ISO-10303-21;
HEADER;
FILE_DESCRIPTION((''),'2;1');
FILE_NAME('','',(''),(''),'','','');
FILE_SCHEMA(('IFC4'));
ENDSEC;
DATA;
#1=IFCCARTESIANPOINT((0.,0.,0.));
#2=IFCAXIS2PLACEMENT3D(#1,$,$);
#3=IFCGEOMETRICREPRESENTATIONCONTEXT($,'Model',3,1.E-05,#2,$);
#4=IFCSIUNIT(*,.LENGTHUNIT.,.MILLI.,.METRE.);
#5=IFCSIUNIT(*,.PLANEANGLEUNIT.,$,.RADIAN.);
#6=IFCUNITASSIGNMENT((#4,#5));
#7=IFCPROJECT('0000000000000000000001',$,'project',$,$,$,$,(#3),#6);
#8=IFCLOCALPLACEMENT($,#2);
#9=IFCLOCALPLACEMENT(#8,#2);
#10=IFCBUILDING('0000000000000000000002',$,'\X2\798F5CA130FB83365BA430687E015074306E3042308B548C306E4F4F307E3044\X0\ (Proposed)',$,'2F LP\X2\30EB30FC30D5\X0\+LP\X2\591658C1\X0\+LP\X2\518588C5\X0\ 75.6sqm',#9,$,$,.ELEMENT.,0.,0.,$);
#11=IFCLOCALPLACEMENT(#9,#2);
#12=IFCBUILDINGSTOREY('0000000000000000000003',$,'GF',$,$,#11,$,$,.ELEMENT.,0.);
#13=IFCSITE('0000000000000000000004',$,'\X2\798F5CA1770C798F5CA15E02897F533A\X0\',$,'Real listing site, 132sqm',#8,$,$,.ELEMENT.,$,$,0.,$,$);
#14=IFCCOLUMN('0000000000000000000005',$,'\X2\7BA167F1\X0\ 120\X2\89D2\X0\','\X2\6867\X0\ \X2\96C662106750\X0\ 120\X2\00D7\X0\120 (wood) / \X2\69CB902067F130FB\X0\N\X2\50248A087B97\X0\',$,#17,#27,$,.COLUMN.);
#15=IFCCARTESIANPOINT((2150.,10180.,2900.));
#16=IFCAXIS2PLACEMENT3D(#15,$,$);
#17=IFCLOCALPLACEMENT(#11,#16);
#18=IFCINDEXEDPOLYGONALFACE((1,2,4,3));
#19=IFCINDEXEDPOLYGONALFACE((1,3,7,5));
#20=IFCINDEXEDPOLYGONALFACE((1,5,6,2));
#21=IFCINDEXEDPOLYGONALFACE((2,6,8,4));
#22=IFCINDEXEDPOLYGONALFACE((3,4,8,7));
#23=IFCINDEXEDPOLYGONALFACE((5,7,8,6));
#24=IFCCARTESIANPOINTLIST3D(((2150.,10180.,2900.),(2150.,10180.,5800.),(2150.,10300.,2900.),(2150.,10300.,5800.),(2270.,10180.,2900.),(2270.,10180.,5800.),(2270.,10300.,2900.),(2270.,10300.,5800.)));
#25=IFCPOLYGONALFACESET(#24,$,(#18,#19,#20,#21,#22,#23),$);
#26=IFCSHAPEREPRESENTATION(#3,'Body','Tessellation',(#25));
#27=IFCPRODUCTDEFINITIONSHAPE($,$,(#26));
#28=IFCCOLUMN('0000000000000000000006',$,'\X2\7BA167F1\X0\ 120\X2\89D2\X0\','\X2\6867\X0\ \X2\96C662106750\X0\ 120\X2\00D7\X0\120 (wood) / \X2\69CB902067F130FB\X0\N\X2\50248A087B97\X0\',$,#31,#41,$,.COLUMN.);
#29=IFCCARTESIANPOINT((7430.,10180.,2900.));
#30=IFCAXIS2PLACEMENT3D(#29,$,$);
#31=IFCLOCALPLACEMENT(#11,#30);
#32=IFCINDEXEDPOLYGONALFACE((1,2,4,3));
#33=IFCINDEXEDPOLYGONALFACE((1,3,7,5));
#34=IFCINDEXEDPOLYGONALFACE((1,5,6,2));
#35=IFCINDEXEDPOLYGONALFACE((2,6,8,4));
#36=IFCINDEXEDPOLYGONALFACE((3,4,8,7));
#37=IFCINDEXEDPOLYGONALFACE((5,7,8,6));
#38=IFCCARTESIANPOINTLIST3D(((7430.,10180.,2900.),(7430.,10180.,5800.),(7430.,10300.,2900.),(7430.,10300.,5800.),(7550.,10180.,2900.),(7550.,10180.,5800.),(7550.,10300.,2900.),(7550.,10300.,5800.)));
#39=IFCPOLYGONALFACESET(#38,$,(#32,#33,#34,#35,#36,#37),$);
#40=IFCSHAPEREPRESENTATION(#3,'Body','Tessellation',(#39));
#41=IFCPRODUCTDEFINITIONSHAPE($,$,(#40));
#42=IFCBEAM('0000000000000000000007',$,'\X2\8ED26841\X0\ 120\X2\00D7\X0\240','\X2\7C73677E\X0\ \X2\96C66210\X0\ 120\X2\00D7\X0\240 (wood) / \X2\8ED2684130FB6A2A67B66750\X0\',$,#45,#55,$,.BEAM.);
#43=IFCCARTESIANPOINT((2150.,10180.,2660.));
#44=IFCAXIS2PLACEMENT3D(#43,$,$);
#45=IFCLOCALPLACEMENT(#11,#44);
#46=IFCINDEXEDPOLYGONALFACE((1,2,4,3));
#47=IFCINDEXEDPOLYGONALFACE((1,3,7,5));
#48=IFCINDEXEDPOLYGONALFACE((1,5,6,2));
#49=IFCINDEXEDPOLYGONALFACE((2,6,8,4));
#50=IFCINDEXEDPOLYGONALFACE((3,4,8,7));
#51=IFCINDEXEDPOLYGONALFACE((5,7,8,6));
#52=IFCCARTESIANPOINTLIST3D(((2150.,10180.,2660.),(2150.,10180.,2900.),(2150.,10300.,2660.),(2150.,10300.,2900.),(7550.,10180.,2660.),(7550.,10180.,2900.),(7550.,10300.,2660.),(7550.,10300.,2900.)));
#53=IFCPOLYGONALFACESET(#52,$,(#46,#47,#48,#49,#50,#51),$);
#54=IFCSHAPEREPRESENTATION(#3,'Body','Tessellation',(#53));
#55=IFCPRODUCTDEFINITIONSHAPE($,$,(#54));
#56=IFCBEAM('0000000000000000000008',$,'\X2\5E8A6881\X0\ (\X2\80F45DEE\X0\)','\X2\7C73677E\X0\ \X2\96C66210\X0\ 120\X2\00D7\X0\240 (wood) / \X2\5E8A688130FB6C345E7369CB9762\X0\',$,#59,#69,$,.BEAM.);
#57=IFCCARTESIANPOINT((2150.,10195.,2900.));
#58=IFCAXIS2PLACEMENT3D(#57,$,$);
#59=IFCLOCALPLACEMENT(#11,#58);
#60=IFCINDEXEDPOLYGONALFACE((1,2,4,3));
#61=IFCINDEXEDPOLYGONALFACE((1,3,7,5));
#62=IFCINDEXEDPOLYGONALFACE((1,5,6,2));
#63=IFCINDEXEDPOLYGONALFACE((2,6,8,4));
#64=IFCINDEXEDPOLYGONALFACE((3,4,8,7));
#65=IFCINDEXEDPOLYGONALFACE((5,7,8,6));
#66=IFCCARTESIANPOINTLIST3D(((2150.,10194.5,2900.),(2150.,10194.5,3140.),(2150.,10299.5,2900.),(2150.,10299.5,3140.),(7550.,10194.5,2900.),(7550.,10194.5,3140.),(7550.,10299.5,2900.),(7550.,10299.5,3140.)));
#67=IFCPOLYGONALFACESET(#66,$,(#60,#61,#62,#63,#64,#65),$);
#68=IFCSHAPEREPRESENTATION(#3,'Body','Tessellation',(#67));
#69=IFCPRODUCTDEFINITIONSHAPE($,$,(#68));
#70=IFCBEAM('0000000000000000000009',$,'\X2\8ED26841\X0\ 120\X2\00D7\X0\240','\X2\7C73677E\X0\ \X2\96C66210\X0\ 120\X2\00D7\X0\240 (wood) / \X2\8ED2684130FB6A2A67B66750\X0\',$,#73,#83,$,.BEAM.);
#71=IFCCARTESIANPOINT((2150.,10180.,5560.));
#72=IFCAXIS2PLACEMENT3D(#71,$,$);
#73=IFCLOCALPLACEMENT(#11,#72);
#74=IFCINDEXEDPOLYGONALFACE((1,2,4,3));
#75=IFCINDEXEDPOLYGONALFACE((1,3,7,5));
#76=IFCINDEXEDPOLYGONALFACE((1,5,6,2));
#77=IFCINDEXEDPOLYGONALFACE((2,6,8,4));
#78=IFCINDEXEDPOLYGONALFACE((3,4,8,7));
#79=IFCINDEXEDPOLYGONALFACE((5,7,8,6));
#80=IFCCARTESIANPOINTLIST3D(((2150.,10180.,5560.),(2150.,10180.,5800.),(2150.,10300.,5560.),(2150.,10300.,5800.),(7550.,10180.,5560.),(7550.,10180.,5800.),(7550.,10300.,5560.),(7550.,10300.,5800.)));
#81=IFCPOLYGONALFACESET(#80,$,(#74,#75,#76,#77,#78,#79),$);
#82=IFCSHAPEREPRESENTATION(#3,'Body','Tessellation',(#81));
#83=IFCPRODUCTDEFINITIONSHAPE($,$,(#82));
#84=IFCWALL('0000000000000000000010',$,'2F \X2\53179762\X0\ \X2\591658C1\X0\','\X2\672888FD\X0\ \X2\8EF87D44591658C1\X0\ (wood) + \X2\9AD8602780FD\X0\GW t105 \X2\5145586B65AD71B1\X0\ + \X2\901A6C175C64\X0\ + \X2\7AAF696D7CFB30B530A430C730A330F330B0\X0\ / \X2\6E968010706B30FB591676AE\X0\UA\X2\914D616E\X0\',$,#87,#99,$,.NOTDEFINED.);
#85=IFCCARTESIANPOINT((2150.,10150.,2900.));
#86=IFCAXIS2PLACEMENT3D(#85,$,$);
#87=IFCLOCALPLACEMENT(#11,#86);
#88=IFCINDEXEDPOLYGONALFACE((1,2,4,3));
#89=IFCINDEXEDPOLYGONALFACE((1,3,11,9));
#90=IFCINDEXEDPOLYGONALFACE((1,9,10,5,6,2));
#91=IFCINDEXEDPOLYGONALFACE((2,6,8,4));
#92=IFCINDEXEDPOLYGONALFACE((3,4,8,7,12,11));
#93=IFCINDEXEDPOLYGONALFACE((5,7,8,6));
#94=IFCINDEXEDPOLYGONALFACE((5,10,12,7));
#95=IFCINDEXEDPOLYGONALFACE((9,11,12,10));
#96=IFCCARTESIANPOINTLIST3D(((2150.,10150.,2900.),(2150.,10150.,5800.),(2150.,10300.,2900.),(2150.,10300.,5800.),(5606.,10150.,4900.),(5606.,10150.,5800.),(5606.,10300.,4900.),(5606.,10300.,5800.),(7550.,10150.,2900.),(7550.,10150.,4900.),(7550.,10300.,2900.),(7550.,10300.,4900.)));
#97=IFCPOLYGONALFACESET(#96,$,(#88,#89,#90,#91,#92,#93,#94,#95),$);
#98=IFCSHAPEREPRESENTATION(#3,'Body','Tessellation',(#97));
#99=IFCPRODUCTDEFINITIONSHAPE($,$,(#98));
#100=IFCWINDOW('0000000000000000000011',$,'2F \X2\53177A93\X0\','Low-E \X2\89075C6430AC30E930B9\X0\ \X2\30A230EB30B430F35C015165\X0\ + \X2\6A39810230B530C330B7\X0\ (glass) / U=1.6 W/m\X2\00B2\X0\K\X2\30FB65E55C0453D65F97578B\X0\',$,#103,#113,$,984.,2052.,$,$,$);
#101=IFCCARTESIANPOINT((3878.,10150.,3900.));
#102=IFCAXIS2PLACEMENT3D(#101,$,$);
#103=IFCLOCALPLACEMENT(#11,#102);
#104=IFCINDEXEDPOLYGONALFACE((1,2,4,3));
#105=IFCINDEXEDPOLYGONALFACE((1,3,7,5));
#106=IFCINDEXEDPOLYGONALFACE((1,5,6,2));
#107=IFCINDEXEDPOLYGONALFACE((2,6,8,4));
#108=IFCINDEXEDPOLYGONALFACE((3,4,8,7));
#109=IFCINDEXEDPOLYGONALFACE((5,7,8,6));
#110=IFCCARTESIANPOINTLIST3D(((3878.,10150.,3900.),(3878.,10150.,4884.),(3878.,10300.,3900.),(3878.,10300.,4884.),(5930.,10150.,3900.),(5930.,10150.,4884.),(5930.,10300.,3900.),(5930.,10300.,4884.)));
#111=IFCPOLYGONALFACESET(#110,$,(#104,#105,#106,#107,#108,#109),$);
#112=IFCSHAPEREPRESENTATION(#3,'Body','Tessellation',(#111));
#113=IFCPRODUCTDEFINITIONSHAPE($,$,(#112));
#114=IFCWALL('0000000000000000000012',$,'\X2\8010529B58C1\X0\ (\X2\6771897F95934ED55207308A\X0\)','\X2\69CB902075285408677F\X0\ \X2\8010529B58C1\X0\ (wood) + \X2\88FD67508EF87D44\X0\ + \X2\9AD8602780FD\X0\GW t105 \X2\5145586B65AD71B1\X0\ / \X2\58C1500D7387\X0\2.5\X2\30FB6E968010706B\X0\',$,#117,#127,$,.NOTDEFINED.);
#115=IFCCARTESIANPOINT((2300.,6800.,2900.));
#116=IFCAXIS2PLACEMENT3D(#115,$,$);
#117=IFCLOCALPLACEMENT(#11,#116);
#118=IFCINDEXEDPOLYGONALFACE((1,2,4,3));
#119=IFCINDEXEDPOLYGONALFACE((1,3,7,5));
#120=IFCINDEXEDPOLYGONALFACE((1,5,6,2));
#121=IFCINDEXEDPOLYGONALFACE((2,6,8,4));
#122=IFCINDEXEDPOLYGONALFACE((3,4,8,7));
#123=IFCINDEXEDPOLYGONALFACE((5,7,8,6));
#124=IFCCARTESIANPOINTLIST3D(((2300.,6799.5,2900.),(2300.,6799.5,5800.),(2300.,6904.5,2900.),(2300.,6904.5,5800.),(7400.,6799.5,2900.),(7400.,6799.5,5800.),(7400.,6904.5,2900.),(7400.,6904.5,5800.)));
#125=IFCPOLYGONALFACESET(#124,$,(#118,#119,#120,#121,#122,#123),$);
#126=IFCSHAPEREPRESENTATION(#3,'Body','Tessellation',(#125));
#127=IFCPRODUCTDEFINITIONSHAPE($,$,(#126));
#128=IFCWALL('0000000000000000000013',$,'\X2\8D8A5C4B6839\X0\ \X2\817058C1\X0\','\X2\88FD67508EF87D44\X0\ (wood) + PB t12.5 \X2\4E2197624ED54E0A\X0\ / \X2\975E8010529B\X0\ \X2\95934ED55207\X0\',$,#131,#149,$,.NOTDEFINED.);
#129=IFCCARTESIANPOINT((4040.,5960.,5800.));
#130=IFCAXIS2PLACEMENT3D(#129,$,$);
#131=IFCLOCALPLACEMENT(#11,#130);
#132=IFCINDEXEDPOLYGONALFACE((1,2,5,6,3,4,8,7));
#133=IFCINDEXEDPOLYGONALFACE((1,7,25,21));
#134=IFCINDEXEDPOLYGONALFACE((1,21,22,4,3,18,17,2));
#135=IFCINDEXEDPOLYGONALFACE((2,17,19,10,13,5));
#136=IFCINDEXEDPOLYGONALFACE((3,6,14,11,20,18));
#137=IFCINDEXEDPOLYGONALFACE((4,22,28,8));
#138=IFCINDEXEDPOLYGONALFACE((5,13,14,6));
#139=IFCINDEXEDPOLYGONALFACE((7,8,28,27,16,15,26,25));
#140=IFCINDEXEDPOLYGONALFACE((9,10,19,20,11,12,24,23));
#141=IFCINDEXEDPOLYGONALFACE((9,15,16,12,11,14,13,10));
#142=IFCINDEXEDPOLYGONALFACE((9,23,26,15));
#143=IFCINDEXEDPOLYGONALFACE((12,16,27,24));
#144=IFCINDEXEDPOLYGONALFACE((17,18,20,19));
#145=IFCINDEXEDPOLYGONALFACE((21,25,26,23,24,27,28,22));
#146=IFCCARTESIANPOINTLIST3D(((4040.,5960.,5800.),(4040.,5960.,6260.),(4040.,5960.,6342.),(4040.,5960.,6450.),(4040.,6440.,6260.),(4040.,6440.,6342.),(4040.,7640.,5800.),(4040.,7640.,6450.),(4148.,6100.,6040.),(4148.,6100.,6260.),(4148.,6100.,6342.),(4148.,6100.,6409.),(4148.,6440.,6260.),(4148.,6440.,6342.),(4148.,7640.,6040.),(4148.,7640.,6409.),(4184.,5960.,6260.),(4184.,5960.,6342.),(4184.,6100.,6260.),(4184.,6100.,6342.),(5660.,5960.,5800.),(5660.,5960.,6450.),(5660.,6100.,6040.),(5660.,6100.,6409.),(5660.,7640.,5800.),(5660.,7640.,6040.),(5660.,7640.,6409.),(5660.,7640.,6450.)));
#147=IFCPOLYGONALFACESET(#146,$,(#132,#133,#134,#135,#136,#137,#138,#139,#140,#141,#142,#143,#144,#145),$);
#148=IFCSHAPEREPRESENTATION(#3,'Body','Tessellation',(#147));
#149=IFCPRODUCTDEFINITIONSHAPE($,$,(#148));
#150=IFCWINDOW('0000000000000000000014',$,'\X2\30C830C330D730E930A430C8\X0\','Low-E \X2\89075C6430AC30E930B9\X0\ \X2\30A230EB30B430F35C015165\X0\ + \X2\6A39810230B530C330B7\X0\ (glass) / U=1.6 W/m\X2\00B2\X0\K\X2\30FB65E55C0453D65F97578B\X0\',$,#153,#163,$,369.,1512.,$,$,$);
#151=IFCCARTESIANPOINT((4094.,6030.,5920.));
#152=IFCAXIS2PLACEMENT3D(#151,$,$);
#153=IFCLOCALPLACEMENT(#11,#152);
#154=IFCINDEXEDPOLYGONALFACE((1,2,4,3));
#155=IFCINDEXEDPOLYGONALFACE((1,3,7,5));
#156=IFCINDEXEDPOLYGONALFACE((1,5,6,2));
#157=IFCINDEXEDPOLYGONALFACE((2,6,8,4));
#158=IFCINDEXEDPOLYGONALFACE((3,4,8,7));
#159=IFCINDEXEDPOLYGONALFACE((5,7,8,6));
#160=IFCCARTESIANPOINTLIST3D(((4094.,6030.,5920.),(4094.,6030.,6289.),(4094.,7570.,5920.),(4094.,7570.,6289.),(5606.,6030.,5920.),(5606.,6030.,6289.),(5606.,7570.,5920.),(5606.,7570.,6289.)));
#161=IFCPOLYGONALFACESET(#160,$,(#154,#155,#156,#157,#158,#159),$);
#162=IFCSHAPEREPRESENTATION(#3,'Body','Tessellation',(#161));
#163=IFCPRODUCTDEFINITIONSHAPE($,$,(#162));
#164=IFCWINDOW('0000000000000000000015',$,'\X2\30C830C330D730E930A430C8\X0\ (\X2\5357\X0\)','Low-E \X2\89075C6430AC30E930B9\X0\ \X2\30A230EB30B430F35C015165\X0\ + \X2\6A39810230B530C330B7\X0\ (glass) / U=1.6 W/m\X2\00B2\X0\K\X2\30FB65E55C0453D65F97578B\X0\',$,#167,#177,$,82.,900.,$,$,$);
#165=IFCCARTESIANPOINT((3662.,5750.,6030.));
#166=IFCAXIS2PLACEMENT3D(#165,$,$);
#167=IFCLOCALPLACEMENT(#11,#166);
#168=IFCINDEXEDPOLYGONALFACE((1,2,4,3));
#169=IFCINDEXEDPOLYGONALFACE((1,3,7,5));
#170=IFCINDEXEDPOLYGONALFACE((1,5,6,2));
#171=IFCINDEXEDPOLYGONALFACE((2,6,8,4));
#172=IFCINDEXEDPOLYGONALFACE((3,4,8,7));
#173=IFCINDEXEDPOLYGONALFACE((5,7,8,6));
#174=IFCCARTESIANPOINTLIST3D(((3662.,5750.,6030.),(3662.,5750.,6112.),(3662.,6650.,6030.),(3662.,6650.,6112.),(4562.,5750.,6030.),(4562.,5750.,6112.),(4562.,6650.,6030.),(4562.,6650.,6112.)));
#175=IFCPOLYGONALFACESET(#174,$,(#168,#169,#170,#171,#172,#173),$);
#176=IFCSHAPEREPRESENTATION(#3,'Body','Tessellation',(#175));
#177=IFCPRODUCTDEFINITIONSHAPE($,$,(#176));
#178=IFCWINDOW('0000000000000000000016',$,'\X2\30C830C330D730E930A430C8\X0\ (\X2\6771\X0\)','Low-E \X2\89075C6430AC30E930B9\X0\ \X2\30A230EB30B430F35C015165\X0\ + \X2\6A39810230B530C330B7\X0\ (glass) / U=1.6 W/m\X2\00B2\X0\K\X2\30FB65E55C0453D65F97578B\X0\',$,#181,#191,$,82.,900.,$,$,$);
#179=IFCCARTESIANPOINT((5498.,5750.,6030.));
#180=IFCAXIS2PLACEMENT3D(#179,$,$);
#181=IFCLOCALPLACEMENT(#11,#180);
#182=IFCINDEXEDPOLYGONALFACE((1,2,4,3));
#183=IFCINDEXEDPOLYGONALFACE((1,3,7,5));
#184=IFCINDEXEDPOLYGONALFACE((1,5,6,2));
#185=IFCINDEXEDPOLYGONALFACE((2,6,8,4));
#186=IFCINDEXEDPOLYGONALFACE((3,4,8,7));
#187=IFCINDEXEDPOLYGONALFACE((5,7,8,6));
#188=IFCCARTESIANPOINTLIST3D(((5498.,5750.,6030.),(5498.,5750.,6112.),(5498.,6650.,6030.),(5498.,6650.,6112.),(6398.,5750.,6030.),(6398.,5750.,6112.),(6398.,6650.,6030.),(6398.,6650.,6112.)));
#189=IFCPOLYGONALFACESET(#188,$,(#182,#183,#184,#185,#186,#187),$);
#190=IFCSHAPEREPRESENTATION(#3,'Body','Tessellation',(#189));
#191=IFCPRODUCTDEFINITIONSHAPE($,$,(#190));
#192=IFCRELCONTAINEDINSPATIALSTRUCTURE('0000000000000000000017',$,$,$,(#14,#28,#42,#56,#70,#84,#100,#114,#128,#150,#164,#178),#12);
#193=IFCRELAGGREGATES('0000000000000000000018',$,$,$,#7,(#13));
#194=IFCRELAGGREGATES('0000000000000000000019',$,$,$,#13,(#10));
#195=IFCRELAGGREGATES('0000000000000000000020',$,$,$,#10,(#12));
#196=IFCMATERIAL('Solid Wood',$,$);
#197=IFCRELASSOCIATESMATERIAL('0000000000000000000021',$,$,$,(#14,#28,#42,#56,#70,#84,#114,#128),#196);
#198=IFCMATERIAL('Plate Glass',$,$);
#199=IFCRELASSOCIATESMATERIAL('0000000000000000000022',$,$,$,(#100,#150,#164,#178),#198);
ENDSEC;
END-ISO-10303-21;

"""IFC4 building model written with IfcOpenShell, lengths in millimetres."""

from ifc_helpers import new_model, si_unit, frame, frame_2d, origin, place, context, project, spatial, rectangle, extrude, material, element, fill, save


model = new_model("IFC4")

# Units and contexts
model_context = context("Model", 3, precision=1e-05, world=origin())
ifc_project = project(units=[si_unit("LENGTHUNIT", "METRE", prefix="MILLI"), si_unit("PLANEANGLEUNIT", "RADIAN")], contexts=[model_context])

# Site, building, storey
site_placement = place(None, origin())
site = spatial("IfcSite", under=ifc_project, at=site_placement, Name="福岡県福岡市西区", ObjectType="Real listing site, 132sqm", CompositionType="ELEMENT", RefElevation=0.0)
building_placement = place(site_placement, origin())
building = spatial("IfcBuilding", under=site, at=building_placement, Name="福岡・茶室と縁側のある和の住まい (Proposed)", ObjectType="2F LPルーフ+LP外壁+LP内装 75.6sqm", CompositionType="ELEMENT", ElevationOfRefHeight=0.0, ElevationOfTerrain=0.0)
storey_placement = place(building_placement, origin())
storey = spatial("IfcBuildingStorey", under=building, at=storey_placement, Name="GF", CompositionType="ELEMENT", Elevation=0.0)

# Columns
ifc_material_1 = material(Name="Solid Wood")
column_1_placement = place(storey_placement, frame((2150.0, 10180.0, 2900.0)))
element("IfcColumn", 1, at=column_1_placement, inside=storey, material=ifc_material_1, Name="管柱 120角", Description="桧 集成材 120×120 (wood) / 構造柱・N値計算", PredefinedType="COLUMN", context=model_context, shape_type="SweptSolid", body=[
    extrude(rectangle(XDim=120.0, YDim=120.0, at=frame_2d((60.0, 60.0))), frame((2150.0, 10180.0, 2900.0)), (0.0, 0.0, 1.0), 2900.0),
])
column_2_placement = place(storey_placement, frame((7430.0, 10180.0, 2900.0)))
element("IfcColumn", 2, at=column_2_placement, inside=storey, material=ifc_material_1, Name="管柱 120角", Description="桧 集成材 120×120 (wood) / 構造柱・N値計算", PredefinedType="COLUMN", context=model_context, shape_type="SweptSolid", body=[
    extrude(rectangle(XDim=120.0, YDim=120.0, at=frame_2d((60.0, 60.0))), frame((7430.0, 10180.0, 2900.0)), (0.0, 0.0, 1.0), 2900.0),
])

# Beams
beam_1_placement = place(storey_placement, frame((2150.0, 10180.0, 2660.0)))
element("IfcBeam", 3, at=beam_1_placement, inside=storey, material=ifc_material_1, Name="軒桁 120×240", Description="米松 集成 120×240 (wood) / 軒桁・横架材", PredefinedType="BEAM", context=model_context, shape_type="SweptSolid", body=[
    extrude(rectangle(XDim=5400.0, YDim=120.0, at=frame_2d((2700.0, 60.0))), frame((2150.0, 10180.0, 2660.0)), (0.0, 0.0, 1.0), 240.0),
])
beam_2_placement = place(storey_placement, frame((2150.0, 10195.0, 2900.0)))
element("IfcBeam", 4, at=beam_2_placement, inside=storey, material=ifc_material_1, Name="床梁 (胴差)", Description="米松 集成 120×240 (wood) / 床梁・水平構面", PredefinedType="BEAM", context=model_context, shape_type="SweptSolid", body=[
    extrude(rectangle(XDim=5400.0, YDim=105.0, at=frame_2d((2700.0, 52.0))), frame((2150.0, 10195.0, 2900.0)), (0.0, 0.0, 1.0), 240.0),
])
beam_3_placement = place(storey_placement, frame((2150.0, 10180.0, 5560.0)))
element("IfcBeam", 5, at=beam_3_placement, inside=storey, material=ifc_material_1, Name="軒桁 120×240", Description="米松 集成 120×240 (wood) / 軒桁・横架材", PredefinedType="BEAM", context=model_context, shape_type="SweptSolid", body=[
    extrude(rectangle(XDim=5400.0, YDim=120.0, at=frame_2d((2700.0, 60.0))), frame((2150.0, 10180.0, 5560.0)), (0.0, 0.0, 1.0), 240.0),
])

# Wall, opening, window
wall_1_placement = place(storey_placement, frame((2150.0, 10150.0, 2900.0)))
wall_1 = element("IfcWall", 6, at=wall_1_placement, inside=storey, material=ifc_material_1, Name="2F 北面 外壁", Description="木製 軸組外壁 (wood) + 高性能GW t105 充填断熱 + 通気層 + 窯業系サイディング / 準耐火・外皮UA配慮", PredefinedType="NOTDEFINED", context=model_context, shape_type="SweptSolid", body=[
    extrude(rectangle(XDim=5400.0, YDim=150.0, at=frame_2d((2700.0, 75.0))), frame((2150.0, 10150.0, 2900.0)), (0.0, 0.0, 1.0), 2900.0),
])
opening_1_placement = place(storey_placement, frame((3878.0, 10150.0, 3900.0)))
opening_1 = element("IfcOpeningElement", 7, at=opening_1_placement, cuts=wall_1, PredefinedType="NOTDEFINED", context=model_context, shape_type="SweptSolid", body=[
    extrude(rectangle(XDim=2052.0, YDim=150.0, at=frame_2d((1026.0, 75.0))), frame((3878.0, 10150.0, 3900.0)), (0.0, 0.0, 1.0), 984.0),
])
ifc_material_2 = material(Name="Plate Glass")
window_1_placement = place(storey_placement, frame((3878.0, 10150.0, 3900.0)))
window_1 = element("IfcWindow", 8, at=window_1_placement, inside=storey, material=ifc_material_2, Name="2F 北窓", Description="Low-E 複層ガラス アルゴン封入 + 樹脂サッシ (glass) / U=1.6 W/m²K・日射取得型", OverallHeight=984.0, OverallWidth=2052.0, context=model_context, shape_type="SweptSolid", body=[
    extrude(rectangle(XDim=2052.0, YDim=150.0, at=frame_2d((1026.0, 75.0))), frame((3878.0, 10150.0, 3900.0)), (0.0, 0.0, 1.0), 984.0),
])
fill(opening_1, window_1)

# Wall
wall_2_placement = place(storey_placement, frame((2300.0, 6800.0, 2900.0)))
element("IfcWall", 9, at=wall_2_placement, inside=storey, material=ifc_material_1, Name="耐力壁 (東西間仕切り)", Description="構造用合板 耐力壁 (wood) + 製材軸組 + 高性能GW t105 充填断熱 / 壁倍率2.5・準耐火", PredefinedType="NOTDEFINED", context=model_context, shape_type="SweptSolid", body=[
    extrude(rectangle(XDim=5100.0, YDim=105.0, at=frame_2d((2550.0, 52.0))), frame((2300.0, 6800.0, 2900.0)), (0.0, 0.0, 1.0), 2900.0),
])

# Wall, openings, windows
wall_3_placement = place(storey_placement, frame((4040.0, 5960.0, 5800.0)))
wall_3 = element("IfcWall", 10, at=wall_3_placement, inside=storey, material=ifc_material_1, Name="越屋根 腰壁", Description="製材軸組 (wood) + PB t12.5 両面仕上 / 非耐力 間仕切", PredefinedType="NOTDEFINED", context=model_context, shape_type="SweptSolid", body=[
    extrude(rectangle(XDim=1620.0, YDim=1680.0, at=frame_2d((810.0, 840.0))), frame((4040.0, 5960.0, 5800.0)), (0.0, 0.0, 1.0), 650.0),
])
opening_2_placement = place(storey_placement, frame((4094.0, 6030.0, 5920.0)))
opening_2 = element("IfcOpeningElement", 11, at=opening_2_placement, cuts=wall_3, PredefinedType="NOTDEFINED", context=model_context, shape_type="SweptSolid", body=[
    extrude(rectangle(XDim=1512.0, YDim=1540.0, at=frame_2d((756.0, 770.0))), frame((4094.0, 6030.0, 5920.0)), (0.0, 0.0, 1.0), 369.0),
])
opening_3_placement = place(storey_placement, frame((3662.0, 5750.0, 6030.0)))
opening_3 = element("IfcOpeningElement", 12, at=opening_3_placement, cuts=wall_3, PredefinedType="NOTDEFINED", context=model_context, shape_type="SweptSolid", body=[
    extrude(rectangle(XDim=900.0, YDim=900.0, at=frame_2d((450.0, 450.0))), frame((3662.0, 5750.0, 6030.0)), (0.0, 0.0, 1.0), 82.0),
])
opening_4_placement = place(storey_placement, frame((5498.0, 5750.0, 6030.0)))
opening_4 = element("IfcOpeningElement", 13, at=opening_4_placement, cuts=wall_3, PredefinedType="NOTDEFINED", context=model_context, shape_type="SweptSolid", body=[
    extrude(rectangle(XDim=900.0, YDim=900.0, at=frame_2d((450.0, 450.0))), frame((5498.0, 5750.0, 6030.0)), (0.0, 0.0, 1.0), 82.0),
])
window_2_placement = place(storey_placement, frame((4094.0, 6030.0, 5920.0)))
window_2 = element("IfcWindow", 14, at=window_2_placement, inside=storey, material=ifc_material_2, Name="トップライト", Description="Low-E 複層ガラス アルゴン封入 + 樹脂サッシ (glass) / U=1.6 W/m²K・日射取得型", OverallHeight=369.0, OverallWidth=1512.0, context=model_context, shape_type="SweptSolid", body=[
    extrude(rectangle(XDim=1512.0, YDim=1540.0, at=frame_2d((756.0, 770.0))), frame((4094.0, 6030.0, 5920.0)), (0.0, 0.0, 1.0), 369.0),
])
fill(opening_2, window_2)
window_3_placement = place(storey_placement, frame((3662.0, 5750.0, 6030.0)))
window_3 = element("IfcWindow", 15, at=window_3_placement, inside=storey, material=ifc_material_2, Name="トップライト (南)", Description="Low-E 複層ガラス アルゴン封入 + 樹脂サッシ (glass) / U=1.6 W/m²K・日射取得型", OverallHeight=82.0, OverallWidth=900.0, context=model_context, shape_type="SweptSolid", body=[
    extrude(rectangle(XDim=900.0, YDim=900.0, at=frame_2d((450.0, 450.0))), frame((3662.0, 5750.0, 6030.0)), (0.0, 0.0, 1.0), 82.0),
])
fill(opening_3, window_3)
window_4_placement = place(storey_placement, frame((5498.0, 5750.0, 6030.0)))
window_4 = element("IfcWindow", 16, at=window_4_placement, inside=storey, material=ifc_material_2, Name="トップライト (東)", Description="Low-E 複層ガラス アルゴン封入 + 樹脂サッシ (glass) / U=1.6 W/m²K・日射取得型", OverallHeight=82.0, OverallWidth=900.0, context=model_context, shape_type="SweptSolid", body=[
    extrude(rectangle(XDim=900.0, YDim=900.0, at=frame_2d((450.0, 450.0))), frame((5498.0, 5750.0, 6030.0)), (0.0, 0.0, 1.0), 82.0),
])
fill(opening_4, window_4)

save(model, "model.ifc")
